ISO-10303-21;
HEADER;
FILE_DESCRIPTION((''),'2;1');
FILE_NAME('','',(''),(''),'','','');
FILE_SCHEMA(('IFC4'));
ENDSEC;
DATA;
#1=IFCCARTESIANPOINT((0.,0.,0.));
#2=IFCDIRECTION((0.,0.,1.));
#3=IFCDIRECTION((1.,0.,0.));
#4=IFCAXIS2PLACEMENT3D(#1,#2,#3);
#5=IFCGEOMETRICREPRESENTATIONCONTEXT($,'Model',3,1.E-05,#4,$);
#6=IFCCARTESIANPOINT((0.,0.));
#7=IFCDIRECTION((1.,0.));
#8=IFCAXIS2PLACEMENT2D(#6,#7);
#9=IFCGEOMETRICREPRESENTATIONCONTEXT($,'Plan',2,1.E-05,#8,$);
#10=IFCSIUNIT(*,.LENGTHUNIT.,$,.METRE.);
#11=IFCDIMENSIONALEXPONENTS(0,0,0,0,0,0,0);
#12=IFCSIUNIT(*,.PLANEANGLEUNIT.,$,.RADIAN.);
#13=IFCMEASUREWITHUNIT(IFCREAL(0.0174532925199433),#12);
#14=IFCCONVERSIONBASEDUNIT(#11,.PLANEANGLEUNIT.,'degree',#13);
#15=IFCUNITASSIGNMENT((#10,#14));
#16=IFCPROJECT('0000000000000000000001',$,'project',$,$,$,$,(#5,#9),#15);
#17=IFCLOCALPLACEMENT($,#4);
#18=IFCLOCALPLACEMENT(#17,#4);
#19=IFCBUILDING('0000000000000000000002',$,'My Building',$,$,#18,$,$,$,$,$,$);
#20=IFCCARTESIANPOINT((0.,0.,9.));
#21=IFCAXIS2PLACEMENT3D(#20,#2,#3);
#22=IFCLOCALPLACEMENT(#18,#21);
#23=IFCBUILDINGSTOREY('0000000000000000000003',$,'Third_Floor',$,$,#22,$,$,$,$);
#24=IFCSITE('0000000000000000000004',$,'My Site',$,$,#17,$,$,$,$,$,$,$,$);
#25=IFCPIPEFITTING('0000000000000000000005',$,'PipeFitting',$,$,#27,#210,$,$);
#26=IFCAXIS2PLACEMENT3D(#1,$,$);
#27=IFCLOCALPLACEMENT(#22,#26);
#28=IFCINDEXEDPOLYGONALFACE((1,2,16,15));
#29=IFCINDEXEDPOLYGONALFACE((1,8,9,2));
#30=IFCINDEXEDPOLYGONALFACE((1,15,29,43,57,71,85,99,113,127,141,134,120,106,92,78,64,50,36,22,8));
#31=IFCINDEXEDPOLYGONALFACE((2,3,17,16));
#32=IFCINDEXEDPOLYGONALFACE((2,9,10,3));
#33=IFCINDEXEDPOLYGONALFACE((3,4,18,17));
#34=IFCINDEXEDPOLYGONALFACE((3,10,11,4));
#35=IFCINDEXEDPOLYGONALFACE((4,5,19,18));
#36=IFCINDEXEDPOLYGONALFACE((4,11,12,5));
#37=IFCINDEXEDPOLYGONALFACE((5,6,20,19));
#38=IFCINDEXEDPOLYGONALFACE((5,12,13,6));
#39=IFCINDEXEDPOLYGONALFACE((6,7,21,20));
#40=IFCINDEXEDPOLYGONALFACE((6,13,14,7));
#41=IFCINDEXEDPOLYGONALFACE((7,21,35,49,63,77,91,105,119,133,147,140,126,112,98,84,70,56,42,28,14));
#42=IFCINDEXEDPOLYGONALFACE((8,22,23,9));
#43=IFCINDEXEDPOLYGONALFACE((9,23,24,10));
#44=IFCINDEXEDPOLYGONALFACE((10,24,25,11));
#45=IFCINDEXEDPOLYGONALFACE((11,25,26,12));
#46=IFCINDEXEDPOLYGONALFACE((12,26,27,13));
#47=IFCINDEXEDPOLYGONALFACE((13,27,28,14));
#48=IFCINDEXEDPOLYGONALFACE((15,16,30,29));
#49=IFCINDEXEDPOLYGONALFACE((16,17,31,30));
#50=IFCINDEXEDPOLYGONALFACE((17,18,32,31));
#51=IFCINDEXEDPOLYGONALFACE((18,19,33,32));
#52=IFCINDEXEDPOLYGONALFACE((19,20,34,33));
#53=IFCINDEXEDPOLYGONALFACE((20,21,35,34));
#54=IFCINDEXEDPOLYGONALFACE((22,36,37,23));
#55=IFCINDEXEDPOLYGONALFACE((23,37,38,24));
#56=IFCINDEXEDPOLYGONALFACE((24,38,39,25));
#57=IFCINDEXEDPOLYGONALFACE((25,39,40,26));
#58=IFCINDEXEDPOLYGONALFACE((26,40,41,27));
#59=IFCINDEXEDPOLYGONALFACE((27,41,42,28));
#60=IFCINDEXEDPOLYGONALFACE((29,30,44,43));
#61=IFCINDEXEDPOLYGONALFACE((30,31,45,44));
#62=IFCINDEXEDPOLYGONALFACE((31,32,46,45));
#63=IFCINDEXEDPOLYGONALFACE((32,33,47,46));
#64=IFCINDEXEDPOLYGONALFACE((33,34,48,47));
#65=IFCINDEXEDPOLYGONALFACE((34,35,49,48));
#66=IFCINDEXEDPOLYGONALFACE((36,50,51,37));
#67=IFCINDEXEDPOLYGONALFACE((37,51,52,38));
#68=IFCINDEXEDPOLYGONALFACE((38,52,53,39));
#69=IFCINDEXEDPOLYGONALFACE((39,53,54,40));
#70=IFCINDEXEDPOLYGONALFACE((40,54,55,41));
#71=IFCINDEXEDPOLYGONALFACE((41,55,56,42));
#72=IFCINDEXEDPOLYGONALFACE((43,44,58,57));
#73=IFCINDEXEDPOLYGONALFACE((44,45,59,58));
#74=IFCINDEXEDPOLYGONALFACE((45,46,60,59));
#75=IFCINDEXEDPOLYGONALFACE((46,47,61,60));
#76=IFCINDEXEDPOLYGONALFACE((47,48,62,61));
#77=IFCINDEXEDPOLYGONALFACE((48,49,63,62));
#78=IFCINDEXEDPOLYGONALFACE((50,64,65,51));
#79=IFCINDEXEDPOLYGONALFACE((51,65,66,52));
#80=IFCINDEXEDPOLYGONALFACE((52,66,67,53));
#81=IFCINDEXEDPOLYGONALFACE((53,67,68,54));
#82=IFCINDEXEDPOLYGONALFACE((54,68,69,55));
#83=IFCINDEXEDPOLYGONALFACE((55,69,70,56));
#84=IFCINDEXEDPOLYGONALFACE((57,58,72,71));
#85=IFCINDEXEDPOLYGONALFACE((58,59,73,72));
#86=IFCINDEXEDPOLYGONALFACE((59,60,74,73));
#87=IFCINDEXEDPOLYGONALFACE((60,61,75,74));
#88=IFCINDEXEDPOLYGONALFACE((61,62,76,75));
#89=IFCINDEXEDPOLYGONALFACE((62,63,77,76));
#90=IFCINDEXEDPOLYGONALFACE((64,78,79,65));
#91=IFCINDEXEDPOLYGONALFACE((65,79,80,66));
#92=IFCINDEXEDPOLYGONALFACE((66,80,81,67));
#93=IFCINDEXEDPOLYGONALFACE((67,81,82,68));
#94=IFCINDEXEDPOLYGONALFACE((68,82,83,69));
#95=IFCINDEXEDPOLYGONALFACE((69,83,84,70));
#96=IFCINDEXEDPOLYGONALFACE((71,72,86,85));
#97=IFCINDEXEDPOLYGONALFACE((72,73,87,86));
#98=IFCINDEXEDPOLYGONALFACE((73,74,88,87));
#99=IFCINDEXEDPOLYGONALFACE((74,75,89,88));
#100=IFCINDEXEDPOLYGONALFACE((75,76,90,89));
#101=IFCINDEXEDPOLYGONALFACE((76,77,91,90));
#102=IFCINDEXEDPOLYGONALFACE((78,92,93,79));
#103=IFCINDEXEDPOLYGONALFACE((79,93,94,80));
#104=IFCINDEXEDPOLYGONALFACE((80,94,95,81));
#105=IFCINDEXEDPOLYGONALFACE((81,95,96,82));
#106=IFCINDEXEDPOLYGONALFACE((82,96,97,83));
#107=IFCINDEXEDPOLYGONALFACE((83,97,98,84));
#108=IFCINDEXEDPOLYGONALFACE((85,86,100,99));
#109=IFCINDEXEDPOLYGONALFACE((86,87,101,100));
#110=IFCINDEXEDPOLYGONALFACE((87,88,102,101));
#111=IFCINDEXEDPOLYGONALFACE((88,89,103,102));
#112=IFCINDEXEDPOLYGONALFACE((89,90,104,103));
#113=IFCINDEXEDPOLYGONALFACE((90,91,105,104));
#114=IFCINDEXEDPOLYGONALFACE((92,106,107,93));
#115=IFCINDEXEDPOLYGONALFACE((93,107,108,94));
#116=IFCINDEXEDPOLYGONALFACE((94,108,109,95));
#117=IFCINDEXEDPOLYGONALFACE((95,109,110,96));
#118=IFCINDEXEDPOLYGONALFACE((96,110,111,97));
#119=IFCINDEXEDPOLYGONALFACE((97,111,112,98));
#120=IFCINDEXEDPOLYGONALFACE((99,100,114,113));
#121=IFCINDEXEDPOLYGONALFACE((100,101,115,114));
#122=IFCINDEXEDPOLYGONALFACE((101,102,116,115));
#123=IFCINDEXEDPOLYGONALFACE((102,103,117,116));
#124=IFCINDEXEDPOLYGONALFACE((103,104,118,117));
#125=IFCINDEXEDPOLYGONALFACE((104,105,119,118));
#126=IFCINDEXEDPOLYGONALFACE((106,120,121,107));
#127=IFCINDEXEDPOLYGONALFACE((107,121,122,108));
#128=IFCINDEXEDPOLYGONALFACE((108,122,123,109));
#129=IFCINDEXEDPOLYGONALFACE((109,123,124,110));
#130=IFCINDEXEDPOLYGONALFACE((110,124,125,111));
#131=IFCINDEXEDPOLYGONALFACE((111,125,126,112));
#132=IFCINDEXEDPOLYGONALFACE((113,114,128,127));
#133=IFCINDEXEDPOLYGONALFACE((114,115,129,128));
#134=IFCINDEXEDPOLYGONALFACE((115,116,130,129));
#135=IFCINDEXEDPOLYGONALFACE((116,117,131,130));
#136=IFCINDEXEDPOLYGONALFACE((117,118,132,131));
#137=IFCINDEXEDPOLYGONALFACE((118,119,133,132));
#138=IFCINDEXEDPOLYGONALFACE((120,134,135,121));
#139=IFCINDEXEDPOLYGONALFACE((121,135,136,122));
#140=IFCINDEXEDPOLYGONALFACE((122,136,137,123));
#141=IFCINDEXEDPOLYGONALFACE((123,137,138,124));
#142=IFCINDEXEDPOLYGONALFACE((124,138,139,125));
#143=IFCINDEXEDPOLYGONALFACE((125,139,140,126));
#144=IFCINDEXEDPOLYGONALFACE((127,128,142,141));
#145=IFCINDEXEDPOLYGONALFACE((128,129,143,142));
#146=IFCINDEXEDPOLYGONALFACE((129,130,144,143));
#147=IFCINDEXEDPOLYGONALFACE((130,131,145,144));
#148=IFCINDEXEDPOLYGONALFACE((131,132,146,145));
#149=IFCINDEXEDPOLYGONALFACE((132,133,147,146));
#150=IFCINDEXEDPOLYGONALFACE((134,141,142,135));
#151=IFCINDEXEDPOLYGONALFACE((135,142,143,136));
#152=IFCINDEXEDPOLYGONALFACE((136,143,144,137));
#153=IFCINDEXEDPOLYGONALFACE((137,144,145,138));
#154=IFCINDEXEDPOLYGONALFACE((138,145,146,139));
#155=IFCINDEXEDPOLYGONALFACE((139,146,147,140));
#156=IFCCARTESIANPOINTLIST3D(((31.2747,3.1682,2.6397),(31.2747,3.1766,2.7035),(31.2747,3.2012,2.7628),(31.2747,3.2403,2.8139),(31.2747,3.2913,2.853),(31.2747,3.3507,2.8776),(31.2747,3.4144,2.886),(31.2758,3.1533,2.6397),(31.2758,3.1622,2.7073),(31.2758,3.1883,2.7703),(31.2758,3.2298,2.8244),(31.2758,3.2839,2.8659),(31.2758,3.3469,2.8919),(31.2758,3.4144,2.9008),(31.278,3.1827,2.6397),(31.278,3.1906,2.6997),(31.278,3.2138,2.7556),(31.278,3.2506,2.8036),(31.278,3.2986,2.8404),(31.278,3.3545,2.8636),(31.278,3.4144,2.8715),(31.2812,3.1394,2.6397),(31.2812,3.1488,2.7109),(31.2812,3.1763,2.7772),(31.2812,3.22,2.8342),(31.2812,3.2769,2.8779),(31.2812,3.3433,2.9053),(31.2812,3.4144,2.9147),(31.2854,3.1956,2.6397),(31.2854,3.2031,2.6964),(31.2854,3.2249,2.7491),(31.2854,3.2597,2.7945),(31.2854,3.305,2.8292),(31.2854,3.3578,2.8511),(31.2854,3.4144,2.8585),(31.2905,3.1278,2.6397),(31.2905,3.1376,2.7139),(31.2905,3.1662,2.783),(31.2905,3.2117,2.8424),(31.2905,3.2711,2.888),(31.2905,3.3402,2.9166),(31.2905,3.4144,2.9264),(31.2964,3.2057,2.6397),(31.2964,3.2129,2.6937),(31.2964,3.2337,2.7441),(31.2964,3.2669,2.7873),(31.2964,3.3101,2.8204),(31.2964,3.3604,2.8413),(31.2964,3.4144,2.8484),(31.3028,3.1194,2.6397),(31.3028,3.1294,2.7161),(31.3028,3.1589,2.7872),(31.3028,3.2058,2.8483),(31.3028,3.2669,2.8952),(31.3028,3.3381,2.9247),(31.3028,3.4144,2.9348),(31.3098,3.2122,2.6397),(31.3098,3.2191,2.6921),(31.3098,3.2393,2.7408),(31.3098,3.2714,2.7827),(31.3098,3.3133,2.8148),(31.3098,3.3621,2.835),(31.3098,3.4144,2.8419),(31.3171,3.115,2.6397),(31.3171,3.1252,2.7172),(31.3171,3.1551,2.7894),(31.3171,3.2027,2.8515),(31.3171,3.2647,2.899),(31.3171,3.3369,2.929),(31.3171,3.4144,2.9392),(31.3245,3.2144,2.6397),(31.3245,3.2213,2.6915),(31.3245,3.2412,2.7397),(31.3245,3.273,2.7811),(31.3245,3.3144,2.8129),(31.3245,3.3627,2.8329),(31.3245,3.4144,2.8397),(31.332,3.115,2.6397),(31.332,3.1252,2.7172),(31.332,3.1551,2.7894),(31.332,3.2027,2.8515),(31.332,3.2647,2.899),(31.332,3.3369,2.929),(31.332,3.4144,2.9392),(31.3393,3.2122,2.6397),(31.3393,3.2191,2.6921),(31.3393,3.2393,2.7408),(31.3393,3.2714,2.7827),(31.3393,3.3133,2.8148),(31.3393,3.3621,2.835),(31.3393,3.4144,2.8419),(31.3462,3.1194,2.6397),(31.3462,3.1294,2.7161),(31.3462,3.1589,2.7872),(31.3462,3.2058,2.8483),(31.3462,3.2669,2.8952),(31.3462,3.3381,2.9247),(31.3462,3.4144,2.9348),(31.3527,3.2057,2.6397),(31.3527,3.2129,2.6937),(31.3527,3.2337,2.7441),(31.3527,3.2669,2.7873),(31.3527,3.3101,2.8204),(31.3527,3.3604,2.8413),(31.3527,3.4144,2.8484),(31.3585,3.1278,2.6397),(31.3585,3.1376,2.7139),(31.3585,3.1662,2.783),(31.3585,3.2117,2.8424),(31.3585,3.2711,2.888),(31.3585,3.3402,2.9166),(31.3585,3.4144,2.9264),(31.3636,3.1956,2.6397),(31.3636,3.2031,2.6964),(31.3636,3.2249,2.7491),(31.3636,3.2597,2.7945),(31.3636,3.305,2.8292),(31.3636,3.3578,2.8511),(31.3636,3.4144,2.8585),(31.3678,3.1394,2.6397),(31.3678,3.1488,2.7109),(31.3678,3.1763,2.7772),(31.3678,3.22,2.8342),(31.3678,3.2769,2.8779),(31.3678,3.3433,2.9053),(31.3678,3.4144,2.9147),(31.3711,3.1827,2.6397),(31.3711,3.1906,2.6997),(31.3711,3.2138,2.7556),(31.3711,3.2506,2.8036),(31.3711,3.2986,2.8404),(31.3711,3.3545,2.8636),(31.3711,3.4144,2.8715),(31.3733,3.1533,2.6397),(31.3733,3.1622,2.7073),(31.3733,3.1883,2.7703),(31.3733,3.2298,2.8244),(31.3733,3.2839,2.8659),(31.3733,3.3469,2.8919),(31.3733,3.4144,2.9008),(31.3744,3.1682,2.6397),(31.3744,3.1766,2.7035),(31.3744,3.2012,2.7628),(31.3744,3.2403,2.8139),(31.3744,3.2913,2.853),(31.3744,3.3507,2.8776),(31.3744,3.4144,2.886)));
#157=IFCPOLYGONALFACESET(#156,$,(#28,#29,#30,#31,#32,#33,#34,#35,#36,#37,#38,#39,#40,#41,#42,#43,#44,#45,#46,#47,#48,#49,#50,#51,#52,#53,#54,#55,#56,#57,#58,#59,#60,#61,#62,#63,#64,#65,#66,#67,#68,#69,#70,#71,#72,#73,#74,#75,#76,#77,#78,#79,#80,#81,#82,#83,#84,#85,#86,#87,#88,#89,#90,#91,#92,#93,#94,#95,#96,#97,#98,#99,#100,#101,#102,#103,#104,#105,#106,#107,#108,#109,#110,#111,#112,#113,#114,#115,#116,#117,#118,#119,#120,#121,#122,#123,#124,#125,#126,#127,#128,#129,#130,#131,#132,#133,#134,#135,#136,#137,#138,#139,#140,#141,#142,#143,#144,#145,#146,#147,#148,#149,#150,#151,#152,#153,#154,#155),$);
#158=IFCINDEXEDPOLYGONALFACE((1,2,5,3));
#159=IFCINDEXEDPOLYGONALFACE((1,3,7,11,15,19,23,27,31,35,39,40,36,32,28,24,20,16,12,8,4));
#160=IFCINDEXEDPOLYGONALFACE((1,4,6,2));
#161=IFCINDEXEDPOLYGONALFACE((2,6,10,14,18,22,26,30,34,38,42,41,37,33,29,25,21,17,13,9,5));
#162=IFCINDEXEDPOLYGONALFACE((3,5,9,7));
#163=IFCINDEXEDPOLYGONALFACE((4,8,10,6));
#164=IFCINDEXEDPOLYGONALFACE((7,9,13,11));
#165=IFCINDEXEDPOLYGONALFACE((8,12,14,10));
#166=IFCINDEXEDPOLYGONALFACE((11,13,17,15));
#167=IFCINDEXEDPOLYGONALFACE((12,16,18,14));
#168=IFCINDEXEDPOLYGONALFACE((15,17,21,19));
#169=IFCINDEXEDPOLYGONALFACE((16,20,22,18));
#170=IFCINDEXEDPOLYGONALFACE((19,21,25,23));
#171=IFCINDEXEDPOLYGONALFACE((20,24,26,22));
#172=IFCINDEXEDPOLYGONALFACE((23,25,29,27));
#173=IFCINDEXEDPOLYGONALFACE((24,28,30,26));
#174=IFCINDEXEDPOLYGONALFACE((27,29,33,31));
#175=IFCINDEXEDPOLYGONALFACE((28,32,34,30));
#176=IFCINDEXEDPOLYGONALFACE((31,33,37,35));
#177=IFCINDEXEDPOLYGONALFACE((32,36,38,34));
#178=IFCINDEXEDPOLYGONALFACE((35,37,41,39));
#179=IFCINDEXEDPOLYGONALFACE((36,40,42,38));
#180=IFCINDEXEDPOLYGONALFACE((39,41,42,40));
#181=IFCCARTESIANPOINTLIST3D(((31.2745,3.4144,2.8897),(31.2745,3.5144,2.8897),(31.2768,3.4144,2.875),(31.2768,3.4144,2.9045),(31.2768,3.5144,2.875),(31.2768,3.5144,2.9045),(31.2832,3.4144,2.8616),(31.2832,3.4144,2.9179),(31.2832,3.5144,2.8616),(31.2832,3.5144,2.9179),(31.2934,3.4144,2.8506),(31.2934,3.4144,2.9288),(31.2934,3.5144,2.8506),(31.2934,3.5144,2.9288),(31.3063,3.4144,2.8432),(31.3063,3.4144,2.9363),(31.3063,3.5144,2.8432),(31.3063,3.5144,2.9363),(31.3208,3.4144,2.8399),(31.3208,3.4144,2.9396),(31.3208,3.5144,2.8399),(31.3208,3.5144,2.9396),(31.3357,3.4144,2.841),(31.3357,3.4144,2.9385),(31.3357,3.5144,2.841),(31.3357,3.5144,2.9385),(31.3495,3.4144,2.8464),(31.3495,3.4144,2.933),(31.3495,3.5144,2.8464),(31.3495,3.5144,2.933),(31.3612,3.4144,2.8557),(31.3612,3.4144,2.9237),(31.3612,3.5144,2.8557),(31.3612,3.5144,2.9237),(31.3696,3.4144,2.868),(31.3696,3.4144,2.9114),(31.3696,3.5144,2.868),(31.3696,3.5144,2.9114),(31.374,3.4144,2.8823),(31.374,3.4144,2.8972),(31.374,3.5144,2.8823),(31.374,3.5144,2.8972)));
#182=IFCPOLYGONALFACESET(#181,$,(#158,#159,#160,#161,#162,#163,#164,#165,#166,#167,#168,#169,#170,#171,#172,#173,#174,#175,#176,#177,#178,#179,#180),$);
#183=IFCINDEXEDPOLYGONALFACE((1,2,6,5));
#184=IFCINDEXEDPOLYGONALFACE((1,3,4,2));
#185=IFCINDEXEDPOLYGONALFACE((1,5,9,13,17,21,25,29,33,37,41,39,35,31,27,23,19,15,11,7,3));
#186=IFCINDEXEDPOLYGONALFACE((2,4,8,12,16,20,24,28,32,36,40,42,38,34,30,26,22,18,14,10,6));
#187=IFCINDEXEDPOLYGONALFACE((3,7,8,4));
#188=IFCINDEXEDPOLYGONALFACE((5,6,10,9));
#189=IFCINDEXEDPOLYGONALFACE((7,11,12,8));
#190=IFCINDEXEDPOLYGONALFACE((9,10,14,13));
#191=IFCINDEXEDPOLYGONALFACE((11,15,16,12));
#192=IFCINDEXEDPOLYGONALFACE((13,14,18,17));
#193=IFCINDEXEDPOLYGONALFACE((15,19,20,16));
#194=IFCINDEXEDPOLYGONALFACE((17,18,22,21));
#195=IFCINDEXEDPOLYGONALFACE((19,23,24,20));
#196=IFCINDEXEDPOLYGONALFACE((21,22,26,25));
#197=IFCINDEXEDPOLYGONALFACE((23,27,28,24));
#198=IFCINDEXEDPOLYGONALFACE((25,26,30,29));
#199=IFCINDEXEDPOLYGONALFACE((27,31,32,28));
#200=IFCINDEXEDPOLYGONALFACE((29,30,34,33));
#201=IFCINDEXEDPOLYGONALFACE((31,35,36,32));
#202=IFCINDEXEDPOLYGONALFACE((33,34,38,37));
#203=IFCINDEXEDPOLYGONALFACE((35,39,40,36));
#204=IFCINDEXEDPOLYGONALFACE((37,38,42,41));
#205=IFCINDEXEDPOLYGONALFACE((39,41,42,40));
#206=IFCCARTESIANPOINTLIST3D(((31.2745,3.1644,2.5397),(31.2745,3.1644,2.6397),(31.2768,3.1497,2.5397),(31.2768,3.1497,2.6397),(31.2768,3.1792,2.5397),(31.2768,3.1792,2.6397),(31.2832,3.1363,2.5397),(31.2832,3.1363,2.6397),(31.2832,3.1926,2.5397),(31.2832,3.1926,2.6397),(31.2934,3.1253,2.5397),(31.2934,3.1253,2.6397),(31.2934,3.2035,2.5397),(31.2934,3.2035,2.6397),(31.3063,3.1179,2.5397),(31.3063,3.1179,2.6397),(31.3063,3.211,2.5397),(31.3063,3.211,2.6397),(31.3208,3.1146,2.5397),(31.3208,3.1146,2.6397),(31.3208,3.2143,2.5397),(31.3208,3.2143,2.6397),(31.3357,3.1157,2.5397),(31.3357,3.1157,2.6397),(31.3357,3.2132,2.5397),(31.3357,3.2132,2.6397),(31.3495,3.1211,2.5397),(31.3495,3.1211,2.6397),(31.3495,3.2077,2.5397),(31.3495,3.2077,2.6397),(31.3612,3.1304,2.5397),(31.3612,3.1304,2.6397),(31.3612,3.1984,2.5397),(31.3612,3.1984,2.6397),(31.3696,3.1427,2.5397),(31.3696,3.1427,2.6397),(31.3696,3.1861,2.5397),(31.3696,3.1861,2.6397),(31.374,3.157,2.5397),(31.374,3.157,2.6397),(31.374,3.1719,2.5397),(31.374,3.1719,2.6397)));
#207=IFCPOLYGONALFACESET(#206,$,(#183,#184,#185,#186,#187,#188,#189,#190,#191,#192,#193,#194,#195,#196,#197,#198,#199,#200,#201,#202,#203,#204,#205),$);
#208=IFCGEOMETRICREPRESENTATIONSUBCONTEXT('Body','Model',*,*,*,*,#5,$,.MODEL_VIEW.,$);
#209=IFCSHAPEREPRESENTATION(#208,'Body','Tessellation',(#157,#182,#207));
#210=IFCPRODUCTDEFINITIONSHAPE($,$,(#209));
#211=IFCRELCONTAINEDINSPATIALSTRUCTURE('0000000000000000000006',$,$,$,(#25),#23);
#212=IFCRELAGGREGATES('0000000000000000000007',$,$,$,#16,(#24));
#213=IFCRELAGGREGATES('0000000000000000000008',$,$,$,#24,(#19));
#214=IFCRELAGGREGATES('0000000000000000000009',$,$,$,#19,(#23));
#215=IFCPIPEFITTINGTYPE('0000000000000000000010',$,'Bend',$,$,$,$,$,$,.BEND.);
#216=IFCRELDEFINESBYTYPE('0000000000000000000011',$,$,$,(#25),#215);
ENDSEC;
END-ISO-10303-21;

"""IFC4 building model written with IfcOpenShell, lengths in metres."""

from ifc_helpers import new_model, entity, si_unit, converted_unit, frame, origin_with_axes, origin_2d_with_axis, place, context, subcontext, project, spatial, circle, extrude, source, transform, mapped, type_object, type_shapes, element, save


model = new_model("IFC4")

# Units and contexts
model_context = context("Model", 3, precision=1e-05, world=origin_with_axes())
plan_context = context("Plan", 2, precision=1e-05, world=origin_2d_with_axis())
body_context_1 = subcontext(model_context, "Body", "Model", "MODEL_VIEW")
ifc_project = project(units=[si_unit("LENGTHUNIT", "METRE"), converted_unit("PLANEANGLEUNIT", "degree", entity("IfcReal", 0.0174532925199433), si_unit("PLANEANGLEUNIT", "RADIAN"), dimensions=[0, 0, 0, 0, 0, 0, 0])], contexts=[model_context, plan_context])

# Site, building, storey
site_placement = place(None, origin_with_axes())
site = spatial("IfcSite", under=ifc_project, at=site_placement, Name="My Site")
building_placement = place(site_placement, origin_with_axes())
building = spatial("IfcBuilding", under=site, at=building_placement, Name="My Building")
storey_placement = place(building_placement, frame((0.0, 0.0, 9.0), z_axis=(0.0, 0.0, 1.0), x_axis=(1.0, 0.0, 0.0)))
storey = spatial("IfcBuildingStorey", under=building, at=storey_placement, Name="Third_Floor")

# Pipe fitting
pipe_fitting_type = type_object("IfcPipeFittingType", Name="Bend", PredefinedType="BEND")
shared_shape_1 = source(origin_with_axes(), body_context_1, "Body", "SolidModel", [
    entity("IfcSweptDiskSolid", entity("IfcIndexedPolyCurve", entity("IfcCartesianPointList3D", [[0.0, 0.0, -0.1], [0.0, -0.0732, -0.2768], [0.0, -0.25, -0.35]]), [entity("IfcArcIndex", [1, 2, 3])]), 0.05),
    extrude(circle(Radius=0.05), origin_with_axes(), (0.0, 0.0, -1.0), 0.1),
    extrude(circle(Radius=0.05), frame((0.0, -0.25, -0.35), z_axis=(0.0, -1.0, 0.0), x_axis=(1.0, 0.0, 0.0)), (0.0, 0.0, 1.0), 0.1),
])
type_shapes(pipe_fitting_type, [shared_shape_1])
for number, where, z_axis, x_axis, name in (
    (1, (31.3245, 3.5144, 2.8897), (0.0, 1.0, 0.0), (-1.0, 0.0, 0.0), "PipeFitting"),
):
    element("IfcPipeFitting", number, at=place(storey_placement, frame(where, z_axis=z_axis, x_axis=x_axis)), inside=storey, type_object=pipe_fitting_type, Name=name, context=body_context_1, shape_type="MappedRepresentation", body=[
        mapped(shared_shape_1, transform((0.0, 0.0, 0.0), x_axis=(1.0, 0.0, 0.0), y_axis=(0.0, 1.0, 0.0), z_axis=(0.0, 0.0, 1.0), scale=1.0)),
    ])

save(model, "model.ifc")
